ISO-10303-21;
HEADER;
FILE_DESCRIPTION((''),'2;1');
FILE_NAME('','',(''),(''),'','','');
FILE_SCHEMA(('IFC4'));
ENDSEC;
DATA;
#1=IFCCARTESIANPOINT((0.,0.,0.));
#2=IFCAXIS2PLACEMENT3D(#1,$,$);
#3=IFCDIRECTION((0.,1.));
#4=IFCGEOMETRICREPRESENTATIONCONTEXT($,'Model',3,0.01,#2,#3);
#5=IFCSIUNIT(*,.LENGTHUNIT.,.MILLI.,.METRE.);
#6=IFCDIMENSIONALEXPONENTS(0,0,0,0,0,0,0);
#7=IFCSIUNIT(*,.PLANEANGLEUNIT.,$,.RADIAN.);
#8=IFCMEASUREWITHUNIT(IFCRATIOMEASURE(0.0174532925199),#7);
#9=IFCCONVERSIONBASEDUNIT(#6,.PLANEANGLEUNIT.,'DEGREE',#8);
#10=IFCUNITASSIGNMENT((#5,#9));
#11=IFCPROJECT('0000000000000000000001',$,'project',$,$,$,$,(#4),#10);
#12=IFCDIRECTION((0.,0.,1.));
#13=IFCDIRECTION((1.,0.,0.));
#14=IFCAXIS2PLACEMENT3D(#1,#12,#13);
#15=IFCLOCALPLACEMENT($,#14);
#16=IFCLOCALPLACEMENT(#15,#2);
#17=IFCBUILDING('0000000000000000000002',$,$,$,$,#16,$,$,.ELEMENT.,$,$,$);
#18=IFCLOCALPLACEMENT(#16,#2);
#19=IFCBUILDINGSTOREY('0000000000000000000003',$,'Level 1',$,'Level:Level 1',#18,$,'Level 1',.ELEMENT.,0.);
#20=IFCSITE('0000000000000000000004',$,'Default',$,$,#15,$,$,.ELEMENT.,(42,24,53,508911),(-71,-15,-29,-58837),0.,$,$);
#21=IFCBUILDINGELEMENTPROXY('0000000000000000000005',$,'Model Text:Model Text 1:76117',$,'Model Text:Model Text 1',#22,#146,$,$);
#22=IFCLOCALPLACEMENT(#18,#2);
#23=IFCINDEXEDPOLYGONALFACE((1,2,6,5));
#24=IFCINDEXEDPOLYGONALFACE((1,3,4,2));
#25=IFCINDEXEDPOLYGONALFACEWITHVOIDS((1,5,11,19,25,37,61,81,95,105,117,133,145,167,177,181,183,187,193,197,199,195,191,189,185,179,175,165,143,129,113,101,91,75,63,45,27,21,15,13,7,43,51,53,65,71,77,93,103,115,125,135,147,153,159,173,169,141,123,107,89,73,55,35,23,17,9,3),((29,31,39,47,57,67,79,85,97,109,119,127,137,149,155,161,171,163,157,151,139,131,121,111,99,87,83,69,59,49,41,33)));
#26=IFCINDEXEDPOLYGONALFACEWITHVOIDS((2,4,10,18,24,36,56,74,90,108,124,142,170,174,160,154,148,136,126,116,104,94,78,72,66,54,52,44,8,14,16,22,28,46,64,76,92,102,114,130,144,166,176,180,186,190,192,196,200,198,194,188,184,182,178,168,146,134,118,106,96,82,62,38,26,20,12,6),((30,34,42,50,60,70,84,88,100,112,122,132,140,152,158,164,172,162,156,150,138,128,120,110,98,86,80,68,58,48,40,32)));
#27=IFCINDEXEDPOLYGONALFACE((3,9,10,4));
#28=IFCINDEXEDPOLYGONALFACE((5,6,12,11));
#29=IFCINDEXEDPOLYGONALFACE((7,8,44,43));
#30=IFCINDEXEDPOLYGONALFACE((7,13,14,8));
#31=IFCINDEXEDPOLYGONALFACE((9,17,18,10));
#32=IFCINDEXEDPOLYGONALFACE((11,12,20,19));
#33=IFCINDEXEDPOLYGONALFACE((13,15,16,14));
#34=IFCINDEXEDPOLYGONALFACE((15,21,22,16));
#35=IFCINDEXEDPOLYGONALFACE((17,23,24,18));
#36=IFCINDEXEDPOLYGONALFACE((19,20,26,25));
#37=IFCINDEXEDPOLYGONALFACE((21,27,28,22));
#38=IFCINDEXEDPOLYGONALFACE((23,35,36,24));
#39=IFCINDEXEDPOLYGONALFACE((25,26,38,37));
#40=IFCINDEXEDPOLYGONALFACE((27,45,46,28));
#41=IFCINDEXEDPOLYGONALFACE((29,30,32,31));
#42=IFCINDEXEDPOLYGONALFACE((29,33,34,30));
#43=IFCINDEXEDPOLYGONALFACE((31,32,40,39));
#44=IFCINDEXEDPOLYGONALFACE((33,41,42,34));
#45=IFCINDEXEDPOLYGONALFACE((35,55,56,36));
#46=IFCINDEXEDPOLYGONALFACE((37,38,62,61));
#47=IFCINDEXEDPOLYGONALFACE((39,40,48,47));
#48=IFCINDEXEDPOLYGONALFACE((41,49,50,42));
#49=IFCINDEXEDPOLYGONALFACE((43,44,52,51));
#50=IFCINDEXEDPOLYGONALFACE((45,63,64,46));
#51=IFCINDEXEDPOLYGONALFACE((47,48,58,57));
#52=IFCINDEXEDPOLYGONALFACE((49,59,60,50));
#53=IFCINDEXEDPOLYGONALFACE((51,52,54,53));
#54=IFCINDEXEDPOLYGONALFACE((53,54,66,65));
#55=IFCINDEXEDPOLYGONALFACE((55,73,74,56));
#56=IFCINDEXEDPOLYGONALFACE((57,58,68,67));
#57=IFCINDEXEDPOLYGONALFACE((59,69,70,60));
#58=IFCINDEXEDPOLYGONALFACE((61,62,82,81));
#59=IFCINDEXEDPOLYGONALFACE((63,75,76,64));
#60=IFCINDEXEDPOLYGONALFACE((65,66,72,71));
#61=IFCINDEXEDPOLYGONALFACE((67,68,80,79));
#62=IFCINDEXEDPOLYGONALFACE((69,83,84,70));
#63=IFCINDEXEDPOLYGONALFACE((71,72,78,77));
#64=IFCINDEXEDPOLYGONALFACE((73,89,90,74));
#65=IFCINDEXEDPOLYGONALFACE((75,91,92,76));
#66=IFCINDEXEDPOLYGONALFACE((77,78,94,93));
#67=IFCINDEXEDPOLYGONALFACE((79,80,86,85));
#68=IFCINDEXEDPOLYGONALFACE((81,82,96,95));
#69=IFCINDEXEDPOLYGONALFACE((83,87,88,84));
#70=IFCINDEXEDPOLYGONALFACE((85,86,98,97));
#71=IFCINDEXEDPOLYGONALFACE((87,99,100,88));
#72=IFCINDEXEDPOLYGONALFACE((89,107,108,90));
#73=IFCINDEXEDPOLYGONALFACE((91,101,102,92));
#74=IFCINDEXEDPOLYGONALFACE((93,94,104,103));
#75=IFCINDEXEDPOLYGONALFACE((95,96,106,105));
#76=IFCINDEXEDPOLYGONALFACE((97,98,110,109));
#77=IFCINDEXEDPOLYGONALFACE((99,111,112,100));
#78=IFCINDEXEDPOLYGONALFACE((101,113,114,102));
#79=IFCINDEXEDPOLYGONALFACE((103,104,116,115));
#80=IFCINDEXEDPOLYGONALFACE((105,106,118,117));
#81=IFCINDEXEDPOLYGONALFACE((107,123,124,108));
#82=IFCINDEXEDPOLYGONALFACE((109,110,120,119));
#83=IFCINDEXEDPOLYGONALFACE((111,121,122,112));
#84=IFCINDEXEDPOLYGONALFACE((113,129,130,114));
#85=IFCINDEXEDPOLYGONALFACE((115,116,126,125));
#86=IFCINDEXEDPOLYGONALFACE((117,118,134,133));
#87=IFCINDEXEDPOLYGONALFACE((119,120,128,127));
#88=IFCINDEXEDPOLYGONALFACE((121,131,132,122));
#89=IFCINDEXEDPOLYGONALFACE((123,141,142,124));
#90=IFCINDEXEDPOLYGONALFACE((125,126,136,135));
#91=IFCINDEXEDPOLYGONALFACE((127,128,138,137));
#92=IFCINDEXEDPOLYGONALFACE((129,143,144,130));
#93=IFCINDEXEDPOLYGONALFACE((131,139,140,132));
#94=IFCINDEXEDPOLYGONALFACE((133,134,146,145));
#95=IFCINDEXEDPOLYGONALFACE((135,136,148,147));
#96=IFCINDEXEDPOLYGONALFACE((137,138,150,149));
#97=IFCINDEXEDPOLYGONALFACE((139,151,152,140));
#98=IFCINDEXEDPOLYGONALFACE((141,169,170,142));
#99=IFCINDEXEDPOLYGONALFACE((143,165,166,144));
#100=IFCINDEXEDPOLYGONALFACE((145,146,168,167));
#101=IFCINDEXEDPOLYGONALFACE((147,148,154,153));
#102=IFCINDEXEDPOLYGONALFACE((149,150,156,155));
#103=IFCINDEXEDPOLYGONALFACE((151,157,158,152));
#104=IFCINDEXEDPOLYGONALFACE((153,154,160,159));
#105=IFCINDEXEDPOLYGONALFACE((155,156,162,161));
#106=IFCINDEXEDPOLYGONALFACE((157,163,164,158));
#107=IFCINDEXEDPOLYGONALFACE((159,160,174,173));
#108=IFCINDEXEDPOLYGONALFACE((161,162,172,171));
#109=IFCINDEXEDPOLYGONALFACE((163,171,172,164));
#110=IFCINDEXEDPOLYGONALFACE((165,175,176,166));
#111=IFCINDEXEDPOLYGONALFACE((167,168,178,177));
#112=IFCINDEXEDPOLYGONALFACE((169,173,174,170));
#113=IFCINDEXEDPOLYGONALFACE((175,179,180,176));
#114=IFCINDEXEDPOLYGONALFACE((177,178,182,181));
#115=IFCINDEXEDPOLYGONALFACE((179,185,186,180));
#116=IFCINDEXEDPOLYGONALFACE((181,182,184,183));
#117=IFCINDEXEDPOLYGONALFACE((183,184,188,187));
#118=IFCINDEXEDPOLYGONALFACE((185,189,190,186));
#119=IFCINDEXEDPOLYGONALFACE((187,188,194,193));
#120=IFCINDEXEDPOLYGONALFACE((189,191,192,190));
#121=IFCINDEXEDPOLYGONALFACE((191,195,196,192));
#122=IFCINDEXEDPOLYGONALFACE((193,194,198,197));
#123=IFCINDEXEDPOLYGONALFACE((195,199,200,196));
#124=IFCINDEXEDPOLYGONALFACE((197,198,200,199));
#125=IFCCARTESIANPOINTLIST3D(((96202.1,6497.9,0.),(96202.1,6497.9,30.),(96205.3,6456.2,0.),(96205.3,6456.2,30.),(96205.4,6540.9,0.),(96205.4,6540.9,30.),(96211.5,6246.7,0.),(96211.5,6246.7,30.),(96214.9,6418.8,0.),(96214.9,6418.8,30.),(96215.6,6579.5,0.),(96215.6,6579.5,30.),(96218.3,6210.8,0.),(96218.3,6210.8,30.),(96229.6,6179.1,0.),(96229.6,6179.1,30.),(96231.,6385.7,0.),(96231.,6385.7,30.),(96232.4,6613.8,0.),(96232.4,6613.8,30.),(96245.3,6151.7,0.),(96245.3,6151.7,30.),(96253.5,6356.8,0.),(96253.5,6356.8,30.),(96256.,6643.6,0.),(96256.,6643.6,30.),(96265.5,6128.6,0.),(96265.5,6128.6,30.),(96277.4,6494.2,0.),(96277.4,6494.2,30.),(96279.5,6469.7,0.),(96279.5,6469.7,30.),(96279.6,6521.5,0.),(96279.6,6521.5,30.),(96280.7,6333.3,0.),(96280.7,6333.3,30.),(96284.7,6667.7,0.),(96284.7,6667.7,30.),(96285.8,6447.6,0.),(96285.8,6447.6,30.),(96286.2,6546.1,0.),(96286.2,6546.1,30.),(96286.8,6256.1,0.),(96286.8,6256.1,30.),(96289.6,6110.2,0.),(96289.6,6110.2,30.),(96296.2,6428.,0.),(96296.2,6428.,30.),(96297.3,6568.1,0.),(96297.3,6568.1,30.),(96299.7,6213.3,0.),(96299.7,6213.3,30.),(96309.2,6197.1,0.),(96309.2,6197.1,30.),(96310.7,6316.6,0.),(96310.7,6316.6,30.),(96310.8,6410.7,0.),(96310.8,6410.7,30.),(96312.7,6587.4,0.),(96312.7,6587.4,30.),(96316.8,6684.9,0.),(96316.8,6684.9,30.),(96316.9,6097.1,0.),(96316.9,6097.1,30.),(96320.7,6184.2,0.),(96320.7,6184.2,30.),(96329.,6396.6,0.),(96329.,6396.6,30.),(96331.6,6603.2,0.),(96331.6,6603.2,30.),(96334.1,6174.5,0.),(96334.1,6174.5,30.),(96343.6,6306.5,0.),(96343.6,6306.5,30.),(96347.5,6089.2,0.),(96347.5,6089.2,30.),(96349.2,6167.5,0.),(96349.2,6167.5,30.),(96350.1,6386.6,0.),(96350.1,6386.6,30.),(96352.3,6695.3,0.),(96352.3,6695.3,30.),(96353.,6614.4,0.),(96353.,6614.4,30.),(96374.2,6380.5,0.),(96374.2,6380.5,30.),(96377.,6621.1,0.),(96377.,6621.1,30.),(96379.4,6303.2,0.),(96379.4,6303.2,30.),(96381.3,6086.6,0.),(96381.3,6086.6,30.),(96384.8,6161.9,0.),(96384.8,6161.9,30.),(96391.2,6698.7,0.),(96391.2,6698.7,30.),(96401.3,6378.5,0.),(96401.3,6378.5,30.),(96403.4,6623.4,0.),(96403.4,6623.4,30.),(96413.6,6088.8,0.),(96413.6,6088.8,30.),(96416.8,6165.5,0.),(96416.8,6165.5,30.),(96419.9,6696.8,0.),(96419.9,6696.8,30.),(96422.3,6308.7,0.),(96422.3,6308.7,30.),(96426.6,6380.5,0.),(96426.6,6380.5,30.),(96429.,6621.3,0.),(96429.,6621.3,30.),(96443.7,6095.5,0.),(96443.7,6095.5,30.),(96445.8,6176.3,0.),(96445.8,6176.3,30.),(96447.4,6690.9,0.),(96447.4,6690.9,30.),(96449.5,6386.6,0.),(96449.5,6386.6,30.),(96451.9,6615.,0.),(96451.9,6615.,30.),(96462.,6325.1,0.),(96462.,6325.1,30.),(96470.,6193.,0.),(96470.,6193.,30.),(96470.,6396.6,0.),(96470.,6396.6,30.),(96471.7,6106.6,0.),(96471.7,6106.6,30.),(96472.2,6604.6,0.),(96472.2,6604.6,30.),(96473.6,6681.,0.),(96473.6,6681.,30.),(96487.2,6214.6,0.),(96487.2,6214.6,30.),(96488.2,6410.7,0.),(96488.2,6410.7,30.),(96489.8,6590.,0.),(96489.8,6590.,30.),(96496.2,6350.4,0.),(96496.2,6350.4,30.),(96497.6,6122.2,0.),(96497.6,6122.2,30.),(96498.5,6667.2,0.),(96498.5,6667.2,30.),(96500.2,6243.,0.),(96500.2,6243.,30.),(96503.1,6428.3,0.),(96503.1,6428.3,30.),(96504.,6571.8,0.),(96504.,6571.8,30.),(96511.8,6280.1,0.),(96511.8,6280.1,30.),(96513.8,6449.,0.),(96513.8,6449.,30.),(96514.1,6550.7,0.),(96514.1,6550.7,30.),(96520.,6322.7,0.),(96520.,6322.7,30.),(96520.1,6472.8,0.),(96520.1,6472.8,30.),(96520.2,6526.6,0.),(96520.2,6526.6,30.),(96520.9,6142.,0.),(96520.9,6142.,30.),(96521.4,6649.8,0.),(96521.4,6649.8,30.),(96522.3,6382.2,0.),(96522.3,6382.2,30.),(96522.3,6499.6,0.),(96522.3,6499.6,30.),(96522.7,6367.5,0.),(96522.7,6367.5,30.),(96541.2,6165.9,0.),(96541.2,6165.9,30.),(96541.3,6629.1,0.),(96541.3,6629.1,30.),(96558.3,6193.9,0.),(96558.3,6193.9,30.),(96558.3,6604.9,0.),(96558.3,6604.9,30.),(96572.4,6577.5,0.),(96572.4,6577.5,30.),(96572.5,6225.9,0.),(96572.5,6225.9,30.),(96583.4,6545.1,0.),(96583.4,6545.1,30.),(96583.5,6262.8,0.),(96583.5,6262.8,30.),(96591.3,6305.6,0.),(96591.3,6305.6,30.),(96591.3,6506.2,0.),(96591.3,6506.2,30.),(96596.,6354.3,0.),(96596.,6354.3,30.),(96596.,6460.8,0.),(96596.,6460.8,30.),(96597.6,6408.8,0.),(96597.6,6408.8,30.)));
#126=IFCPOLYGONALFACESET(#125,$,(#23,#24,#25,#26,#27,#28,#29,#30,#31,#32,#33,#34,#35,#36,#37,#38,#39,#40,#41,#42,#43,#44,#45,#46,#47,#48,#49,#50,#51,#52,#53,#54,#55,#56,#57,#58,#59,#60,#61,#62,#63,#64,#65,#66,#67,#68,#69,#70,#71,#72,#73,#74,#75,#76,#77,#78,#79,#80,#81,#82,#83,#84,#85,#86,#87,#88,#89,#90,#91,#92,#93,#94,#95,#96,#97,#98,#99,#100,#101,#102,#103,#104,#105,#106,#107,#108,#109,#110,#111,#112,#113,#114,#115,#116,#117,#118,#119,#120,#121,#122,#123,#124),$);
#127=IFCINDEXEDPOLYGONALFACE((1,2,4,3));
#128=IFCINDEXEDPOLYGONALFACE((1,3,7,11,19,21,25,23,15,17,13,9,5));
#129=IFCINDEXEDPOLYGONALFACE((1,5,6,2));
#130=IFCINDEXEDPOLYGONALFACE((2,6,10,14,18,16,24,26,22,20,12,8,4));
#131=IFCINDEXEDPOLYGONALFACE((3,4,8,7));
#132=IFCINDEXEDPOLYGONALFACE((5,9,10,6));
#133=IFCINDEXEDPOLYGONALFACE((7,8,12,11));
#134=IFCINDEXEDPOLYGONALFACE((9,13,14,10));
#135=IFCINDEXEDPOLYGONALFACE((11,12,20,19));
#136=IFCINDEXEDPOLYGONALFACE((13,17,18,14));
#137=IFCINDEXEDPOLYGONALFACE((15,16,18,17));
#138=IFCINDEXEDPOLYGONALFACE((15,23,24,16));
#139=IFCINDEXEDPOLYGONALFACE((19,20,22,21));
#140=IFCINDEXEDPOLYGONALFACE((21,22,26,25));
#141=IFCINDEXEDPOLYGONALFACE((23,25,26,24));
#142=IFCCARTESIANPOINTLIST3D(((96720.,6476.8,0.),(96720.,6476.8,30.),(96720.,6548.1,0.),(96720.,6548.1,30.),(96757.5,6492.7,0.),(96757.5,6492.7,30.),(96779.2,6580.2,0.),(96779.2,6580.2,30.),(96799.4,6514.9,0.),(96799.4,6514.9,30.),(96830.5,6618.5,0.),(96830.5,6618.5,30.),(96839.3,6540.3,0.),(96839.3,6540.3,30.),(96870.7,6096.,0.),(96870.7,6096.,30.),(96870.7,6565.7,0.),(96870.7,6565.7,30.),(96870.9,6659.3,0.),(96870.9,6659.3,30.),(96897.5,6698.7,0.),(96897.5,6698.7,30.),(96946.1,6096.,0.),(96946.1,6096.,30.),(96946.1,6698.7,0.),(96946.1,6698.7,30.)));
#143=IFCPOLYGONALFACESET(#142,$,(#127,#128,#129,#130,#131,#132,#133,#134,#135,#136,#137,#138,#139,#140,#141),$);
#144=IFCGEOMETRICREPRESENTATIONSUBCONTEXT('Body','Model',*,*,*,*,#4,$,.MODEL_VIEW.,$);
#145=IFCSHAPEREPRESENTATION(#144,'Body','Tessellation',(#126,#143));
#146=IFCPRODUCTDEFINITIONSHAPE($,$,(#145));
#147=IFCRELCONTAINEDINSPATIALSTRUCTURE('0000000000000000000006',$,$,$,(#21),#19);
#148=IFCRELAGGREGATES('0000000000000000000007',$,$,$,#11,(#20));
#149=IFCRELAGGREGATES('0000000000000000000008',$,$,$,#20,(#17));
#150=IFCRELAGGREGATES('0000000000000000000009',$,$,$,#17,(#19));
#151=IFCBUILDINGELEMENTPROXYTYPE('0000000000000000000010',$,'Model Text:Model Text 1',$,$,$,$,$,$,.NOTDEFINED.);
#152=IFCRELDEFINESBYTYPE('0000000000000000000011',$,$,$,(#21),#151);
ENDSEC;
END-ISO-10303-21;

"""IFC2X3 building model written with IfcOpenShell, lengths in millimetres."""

from ifc_helpers import new_model, entity, si_unit, converted_unit, direction, frame, origin, origin_with_axes, place, context, subcontext, project, spatial, polyline, outline, extrude, type_object, element, save


model = new_model("IFC2X3")

# Units and contexts
model_context = context("Model", 3, precision=0.01, world=origin(), true_north=direction((0.0, 1.0)))
body_context = subcontext(model_context, "Body", "Model", "MODEL_VIEW")
ifc_project = project(units=[si_unit("LENGTHUNIT", "METRE", prefix="MILLI"), converted_unit("PLANEANGLEUNIT", "DEGREE", entity("IfcRatioMeasure", 0.0174532925199), si_unit("PLANEANGLEUNIT", "RADIAN"), dimensions=[0, 0, 0, 0, 0, 0, 0])], contexts=[model_context])

# Site, building, storey
site_placement = place(None, origin_with_axes())
site = spatial("IfcSite", under=ifc_project, at=site_placement, Name="Default", CompositionType="ELEMENT", RefLatitude=(42, 24, 53, 508911), RefLongitude=(-71, -15, -29, -58837), RefElevation=0.0)
building_placement = place(site_placement, origin())
building = spatial("IfcBuilding", under=site, at=building_placement, CompositionType="ELEMENT")
storey_placement = place(building_placement, origin())
storey = spatial("IfcBuildingStorey", under=building, at=storey_placement, Name="Level 1", ObjectType="Level:Level 1", LongName="Level 1", CompositionType="ELEMENT", Elevation=0.0)

# Building element proxy
building_element_proxy_type_1 = type_object("IfcBuildingElementProxyType", Name="Model Text:Model Text 1", PredefinedType="NOTDEFINED")
proxy_1_placement = place(storey_placement, frame((96202.1, 6086.6, 0.0)))
element("IfcBuildingElementProxy", 1, at=proxy_1_placement, inside=storey, type_object=building_element_proxy_type_1, Name="Model Text:Model Text 1:76117", ObjectType="Model Text:Model Text 1", context=body_context, shape_type="SweptSolid", body=[
    extrude(outline(polyline([(63.9, -207.4), (100.4, -207.4), (133.6, -202.3), (163.4, -191.9), (189.9, -176.3), (212.5, -156.1), (230.5, -131.7), (243.9, -103.1), (252.8, -70.4), (256.6, -38.2), (255.6, -7.4), (249.9, 22.2), (239.4, 50.6), (224.2, 77.1), (204.5, 101.5), (180.3, 123.5), (151.4, 143.4), (117.2, 161.0), (76.6, 176.7), (29.6, 190.4), (-23.7, 202.1), (-75.0, 210.2), (-120.5, 214.0), (-160.2, 213.5), (-194.1, 208.7), (-223.7, 199.9), (-250.5, 187.7), (-274.6, 172.0), (-296.0, 152.8), (-314.2, 130.8), (-328.7, 106.9), (-339.6, 81.0), (-346.9, 53.2), (-350.7, 14.3), (-347.2, -22.5), (-336.2, -57.2), (-317.8, -89.9), (-292.9, -118.6), (-262.4, -141.6), (-226.4, -158.7), (-184.7, -170.0), (-143.2, -174.6), (-104.6, -172.1), (-69.1, -162.4), (-36.5, -145.7), (-8.4, -123.4), (13.6, -97.0), (29.6, -66.5), (39.6, -32.0), (42.2, 11.2), (33.4, 53.3), (14.9, 91.6), (-11.5, 123.1), (3.0, 120.8), (46.6, 109.8), (86.9, 93.9), (121.2, 75.6), (146.7, 57.5), (164.6, 36.5), (176.6, 9.7), (181.8, -20.8), (179.4, -52.9), (167.3, -86.8), (157.6, -100.4), (145.5, -111.8), (130.8, -120.7), (113.0, -127.0), (68.6, -131.7), (63.9, -207.4)]), holes=[polyline([(-126.9, 145.0), (-100.9, 137.9), (-78.7, 127.2), (-60.4, 112.9), (-45.8, 94.9), (-35.4, 74.4), (-29.3, 52.4), (-27.7, 28.8), (-30.4, 3.6), (-37.4, -22.6), (-47.8, -45.2), (-61.6, -64.1), (-78.8, -79.4), (-98.5, -90.5), (-119.8, -97.1), (-142.6, -99.1), (-167.1, -96.6), (-193.5, -89.4), (-216.5, -78.3), (-236.0, -63.4), (-252.1, -44.6), (-264.0, -23.1), (-271.1, 0.0), (-273.3, 24.8), (-270.6, 51.2), (-263.8, 75.9), (-253.4, 97.3), (-239.3, 115.2), (-221.7, 129.8), (-201.2, 140.4), (-178.6, 146.5), (-153.8, 148.0), (-126.9, 145.0)])]), frame((201.4, 261.4, 0.0), z_axis=(0.0, 0.0, 1.0), x_axis=(0.185967, -0.982556, 0.0)), (0.0, 0.0, 1.0), 30.0),
    extrude(outline(polyline([(-410.6, -111.6), (192.1, -111.6), (192.1, -63.1), (152.7, -36.4), (111.9, 4.0), (73.6, 55.2), (41.4, 114.4), (-29.8, 114.4), (-13.9, 77.0), (8.3, 35.1), (33.7, -4.8), (59.1, -36.3), (-410.6, -36.3), (-410.6, -111.6)])), frame((632.4, 420.0, 0.0), z_axis=(0.0, 0.0, 1.0), x_axis=(0.0, 1.0, 0.0)), (0.0, 0.0, 1.0), 30.0),
])

save(model, "model.ifc")
